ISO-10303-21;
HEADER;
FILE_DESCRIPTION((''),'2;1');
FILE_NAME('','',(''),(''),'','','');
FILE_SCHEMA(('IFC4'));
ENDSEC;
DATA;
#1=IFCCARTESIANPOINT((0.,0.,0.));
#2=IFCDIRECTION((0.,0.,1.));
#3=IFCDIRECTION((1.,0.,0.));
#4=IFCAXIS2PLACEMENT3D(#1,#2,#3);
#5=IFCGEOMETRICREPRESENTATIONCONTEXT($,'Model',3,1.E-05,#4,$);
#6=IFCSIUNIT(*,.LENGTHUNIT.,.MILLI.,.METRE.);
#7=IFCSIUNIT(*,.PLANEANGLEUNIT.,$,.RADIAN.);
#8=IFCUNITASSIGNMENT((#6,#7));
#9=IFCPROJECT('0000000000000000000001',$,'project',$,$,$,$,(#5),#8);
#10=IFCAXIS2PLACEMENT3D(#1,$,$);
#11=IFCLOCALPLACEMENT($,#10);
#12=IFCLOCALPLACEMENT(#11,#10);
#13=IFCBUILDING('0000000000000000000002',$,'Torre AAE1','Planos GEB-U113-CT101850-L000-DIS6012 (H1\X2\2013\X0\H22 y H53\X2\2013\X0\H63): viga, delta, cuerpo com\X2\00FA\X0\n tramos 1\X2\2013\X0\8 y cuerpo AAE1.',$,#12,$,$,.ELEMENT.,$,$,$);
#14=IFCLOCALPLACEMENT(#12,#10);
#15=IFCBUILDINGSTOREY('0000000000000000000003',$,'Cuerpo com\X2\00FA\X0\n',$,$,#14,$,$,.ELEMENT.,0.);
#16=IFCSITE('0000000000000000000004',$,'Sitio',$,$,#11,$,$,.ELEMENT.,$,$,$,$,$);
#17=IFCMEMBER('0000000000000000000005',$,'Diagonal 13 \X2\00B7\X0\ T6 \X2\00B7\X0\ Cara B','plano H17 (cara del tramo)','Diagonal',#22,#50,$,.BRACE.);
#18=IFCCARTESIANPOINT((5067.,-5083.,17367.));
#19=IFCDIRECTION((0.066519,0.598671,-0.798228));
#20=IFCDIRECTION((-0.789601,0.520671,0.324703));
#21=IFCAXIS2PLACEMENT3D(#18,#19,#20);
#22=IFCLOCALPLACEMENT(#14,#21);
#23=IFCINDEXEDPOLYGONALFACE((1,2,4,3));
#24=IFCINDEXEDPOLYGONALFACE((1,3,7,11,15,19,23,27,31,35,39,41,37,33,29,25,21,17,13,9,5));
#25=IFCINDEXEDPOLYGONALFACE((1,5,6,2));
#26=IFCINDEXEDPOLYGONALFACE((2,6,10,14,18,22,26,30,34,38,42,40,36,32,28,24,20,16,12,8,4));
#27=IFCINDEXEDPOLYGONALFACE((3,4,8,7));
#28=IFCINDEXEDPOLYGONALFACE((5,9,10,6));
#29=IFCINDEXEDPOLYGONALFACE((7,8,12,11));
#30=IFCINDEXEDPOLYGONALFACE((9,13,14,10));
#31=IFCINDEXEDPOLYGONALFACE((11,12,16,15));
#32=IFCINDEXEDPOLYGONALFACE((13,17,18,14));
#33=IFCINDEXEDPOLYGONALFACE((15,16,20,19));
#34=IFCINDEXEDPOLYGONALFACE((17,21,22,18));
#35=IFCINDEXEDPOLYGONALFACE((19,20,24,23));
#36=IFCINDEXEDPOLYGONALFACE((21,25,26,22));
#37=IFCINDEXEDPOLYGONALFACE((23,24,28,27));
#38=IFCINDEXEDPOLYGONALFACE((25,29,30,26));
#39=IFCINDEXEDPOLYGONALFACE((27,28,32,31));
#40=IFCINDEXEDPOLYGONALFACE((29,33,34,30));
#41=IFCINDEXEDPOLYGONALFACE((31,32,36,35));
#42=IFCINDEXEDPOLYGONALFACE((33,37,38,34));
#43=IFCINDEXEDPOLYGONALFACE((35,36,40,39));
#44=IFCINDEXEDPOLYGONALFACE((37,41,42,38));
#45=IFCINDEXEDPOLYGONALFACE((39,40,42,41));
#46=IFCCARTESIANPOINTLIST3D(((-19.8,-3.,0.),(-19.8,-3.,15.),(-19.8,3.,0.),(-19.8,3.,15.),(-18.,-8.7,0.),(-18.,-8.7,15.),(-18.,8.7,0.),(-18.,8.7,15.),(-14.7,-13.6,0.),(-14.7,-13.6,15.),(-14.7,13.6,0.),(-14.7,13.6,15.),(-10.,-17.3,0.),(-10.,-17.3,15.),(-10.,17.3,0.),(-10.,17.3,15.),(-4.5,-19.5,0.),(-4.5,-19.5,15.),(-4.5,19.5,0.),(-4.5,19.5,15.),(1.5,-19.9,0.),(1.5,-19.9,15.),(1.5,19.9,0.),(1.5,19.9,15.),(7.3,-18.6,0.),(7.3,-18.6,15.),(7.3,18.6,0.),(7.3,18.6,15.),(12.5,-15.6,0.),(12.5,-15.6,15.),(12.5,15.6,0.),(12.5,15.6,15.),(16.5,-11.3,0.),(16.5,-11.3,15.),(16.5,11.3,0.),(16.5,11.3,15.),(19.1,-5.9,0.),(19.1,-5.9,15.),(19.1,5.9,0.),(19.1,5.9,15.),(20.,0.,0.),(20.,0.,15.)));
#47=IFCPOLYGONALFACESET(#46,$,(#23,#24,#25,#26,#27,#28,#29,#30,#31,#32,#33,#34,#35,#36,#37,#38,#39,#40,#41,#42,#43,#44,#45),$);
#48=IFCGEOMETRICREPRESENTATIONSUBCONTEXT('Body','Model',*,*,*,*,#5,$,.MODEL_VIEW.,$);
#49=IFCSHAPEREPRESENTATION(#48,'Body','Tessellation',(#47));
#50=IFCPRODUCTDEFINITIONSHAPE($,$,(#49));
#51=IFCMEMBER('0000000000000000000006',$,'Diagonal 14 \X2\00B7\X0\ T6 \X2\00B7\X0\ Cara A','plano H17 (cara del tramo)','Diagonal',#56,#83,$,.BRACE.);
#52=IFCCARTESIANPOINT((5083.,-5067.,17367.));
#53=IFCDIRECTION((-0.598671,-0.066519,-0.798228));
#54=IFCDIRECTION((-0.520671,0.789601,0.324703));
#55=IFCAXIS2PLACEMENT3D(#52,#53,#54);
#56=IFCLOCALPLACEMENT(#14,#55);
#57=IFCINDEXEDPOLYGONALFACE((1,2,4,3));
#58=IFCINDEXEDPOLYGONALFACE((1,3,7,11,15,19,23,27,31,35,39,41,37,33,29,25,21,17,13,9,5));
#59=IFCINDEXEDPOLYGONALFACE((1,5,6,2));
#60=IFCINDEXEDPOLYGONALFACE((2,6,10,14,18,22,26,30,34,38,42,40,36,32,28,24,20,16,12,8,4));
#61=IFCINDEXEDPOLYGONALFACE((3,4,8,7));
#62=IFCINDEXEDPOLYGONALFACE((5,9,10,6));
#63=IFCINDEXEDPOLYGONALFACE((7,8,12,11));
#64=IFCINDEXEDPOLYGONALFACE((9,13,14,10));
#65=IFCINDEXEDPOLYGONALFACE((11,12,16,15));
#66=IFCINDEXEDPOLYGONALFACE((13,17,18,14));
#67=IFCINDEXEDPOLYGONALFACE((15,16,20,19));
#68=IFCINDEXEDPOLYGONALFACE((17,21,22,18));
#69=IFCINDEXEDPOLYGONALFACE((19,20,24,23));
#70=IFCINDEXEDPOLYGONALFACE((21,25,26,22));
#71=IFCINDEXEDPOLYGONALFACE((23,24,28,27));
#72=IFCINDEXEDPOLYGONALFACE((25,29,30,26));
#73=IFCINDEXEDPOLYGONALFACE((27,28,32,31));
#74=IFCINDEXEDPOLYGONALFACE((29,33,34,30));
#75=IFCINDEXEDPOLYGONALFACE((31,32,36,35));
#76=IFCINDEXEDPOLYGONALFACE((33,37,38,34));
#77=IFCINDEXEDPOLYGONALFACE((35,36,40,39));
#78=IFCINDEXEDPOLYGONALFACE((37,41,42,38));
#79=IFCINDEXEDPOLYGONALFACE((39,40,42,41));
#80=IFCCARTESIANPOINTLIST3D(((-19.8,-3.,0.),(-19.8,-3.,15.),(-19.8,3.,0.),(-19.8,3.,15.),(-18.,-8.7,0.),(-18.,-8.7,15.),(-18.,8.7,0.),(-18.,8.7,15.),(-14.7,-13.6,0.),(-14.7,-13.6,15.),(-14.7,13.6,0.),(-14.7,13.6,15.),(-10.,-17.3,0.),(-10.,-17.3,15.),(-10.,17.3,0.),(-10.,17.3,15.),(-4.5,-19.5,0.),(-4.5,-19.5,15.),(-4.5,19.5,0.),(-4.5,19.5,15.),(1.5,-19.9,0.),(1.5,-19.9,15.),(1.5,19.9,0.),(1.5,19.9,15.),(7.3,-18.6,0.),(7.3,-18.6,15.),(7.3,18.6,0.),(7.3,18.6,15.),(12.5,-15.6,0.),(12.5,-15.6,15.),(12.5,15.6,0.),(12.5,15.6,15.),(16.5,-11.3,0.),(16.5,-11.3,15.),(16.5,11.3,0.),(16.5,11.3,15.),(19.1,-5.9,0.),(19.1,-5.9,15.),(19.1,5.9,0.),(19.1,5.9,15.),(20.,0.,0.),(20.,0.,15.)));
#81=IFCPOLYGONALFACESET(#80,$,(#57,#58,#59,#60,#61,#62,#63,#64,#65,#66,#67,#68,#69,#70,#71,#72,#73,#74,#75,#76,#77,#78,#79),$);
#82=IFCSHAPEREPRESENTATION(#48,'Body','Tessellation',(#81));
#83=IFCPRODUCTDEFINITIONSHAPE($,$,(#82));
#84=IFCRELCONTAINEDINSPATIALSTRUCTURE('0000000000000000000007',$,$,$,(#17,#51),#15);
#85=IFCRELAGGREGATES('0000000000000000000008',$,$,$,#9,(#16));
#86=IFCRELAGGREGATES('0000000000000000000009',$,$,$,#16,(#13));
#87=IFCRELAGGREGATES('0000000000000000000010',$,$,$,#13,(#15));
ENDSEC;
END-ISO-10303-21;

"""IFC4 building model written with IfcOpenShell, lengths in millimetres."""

from ifc_helpers import new_model, si_unit, frame, origin, origin_with_axes, place, context, subcontext, project, spatial, circle, extrude, element, save


model = new_model("IFC4")

# Units and contexts
model_context = context("Model", 3, precision=1e-05, world=origin_with_axes())
body_context = subcontext(model_context, "Body", "Model", "MODEL_VIEW")
ifc_project = project(units=[si_unit("LENGTHUNIT", "METRE", prefix="MILLI"), si_unit("PLANEANGLEUNIT", "RADIAN")], contexts=[model_context])

# Site, building, storey
site_placement = place(None, origin())
site = spatial("IfcSite", under=ifc_project, at=site_placement, Name="Sitio", CompositionType="ELEMENT")
building_placement = place(site_placement, origin())
building = spatial("IfcBuilding", under=site, at=building_placement, Name="Torre AAE1", Description="Planos GEB-U113-CT101850-L000-DIS6012 (H1–H22 y H53–H63): viga, delta, cuerpo común tramos 1–8 y cuerpo AAE1.", CompositionType="ELEMENT")
storey_placement = place(building_placement, origin())
storey = spatial("IfcBuildingStorey", under=building, at=storey_placement, Name="Cuerpo común", CompositionType="ELEMENT", Elevation=0.0)

# Members
for number, where, z_axis, x_axis, name in (
    (1, (5067.0, -5083.0, 17367.0), (0.066519, 0.598671, -0.798228), (-0.789601, 0.520671, 0.324703), "Diagonal 13 · T6 · Cara B"),
    (2, (5083.0, -5067.0, 17367.0), (-0.598671, -0.066519, -0.798228), (-0.520671, 0.789601, 0.324703), "Diagonal 14 · T6 · Cara A"),
):
    element("IfcMember", number, at=place(storey_placement, frame(where, z_axis=z_axis, x_axis=x_axis)), inside=storey, Name=name, Description="plano H17 (cara del tramo)", ObjectType="Diagonal", PredefinedType="BRACE", context=body_context, shape_type="SweptSolid", body=[
        extrude(circle(Radius=20.0), None, (0.0, 0.0, 1.0), 15.0),
    ])

save(model, "model.ifc")
